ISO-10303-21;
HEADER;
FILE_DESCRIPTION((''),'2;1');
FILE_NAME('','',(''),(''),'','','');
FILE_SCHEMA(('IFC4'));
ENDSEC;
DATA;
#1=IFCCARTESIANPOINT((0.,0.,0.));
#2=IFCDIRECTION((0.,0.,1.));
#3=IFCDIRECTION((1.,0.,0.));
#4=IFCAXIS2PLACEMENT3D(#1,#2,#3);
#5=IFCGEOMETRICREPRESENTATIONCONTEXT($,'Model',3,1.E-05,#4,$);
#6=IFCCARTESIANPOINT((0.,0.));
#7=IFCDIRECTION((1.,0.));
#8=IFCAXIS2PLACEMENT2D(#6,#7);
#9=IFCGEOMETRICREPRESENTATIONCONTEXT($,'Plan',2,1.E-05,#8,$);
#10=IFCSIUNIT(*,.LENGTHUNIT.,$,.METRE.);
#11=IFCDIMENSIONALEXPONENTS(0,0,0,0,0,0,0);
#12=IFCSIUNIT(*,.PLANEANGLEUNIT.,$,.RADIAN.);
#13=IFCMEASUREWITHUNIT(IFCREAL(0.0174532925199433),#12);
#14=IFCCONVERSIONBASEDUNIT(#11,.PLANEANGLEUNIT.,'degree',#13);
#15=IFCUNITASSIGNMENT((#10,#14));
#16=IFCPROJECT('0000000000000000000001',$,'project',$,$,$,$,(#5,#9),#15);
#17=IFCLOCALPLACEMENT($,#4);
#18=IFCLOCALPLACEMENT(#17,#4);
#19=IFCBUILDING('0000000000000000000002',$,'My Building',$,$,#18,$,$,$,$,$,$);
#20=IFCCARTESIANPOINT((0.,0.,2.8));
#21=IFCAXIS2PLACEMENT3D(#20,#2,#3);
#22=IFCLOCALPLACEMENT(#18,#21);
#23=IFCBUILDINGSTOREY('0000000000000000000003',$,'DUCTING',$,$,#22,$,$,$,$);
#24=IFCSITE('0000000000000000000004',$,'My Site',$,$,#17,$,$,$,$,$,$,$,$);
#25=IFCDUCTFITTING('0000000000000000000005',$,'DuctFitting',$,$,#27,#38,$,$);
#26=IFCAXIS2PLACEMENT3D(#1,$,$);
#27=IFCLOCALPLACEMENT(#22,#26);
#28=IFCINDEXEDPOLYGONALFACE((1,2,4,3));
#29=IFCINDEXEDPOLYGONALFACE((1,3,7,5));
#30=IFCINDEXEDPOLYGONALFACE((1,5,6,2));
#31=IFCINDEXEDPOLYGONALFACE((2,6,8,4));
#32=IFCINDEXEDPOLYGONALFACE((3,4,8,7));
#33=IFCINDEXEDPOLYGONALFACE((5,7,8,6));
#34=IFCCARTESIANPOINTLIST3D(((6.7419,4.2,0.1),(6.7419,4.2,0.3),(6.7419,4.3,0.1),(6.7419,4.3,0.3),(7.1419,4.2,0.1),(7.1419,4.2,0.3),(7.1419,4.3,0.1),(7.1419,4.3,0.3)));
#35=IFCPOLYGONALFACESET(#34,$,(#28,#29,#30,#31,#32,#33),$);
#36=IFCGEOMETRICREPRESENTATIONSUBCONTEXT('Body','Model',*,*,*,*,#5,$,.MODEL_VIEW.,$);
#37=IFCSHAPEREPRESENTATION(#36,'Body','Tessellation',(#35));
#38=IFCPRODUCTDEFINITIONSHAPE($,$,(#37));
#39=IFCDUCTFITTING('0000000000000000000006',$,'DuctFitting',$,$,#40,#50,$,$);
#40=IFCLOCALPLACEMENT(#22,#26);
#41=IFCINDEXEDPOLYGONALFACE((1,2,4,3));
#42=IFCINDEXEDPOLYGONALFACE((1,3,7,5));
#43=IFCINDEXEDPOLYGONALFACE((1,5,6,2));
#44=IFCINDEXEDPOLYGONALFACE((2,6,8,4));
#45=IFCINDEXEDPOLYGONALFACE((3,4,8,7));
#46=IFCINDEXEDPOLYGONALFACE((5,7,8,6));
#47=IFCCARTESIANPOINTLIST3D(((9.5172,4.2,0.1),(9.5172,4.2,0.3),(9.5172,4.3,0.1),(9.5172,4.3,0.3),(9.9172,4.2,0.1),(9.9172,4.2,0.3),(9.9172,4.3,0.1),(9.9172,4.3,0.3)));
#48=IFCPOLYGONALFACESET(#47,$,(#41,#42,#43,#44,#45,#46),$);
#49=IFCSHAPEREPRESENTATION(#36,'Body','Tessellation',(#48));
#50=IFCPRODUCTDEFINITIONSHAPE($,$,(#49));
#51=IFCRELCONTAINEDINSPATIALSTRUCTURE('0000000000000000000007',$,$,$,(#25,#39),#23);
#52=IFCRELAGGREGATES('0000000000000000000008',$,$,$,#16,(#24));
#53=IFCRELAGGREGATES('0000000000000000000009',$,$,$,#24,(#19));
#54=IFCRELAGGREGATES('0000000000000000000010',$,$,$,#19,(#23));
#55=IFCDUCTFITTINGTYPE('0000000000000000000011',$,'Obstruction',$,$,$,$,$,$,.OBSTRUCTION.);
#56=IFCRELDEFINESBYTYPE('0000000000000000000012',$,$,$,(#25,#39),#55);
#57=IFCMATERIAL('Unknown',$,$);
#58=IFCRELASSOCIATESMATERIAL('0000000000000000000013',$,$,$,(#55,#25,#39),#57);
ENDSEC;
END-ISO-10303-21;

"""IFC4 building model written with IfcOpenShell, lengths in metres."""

from ifc_helpers import new_model, entity, si_unit, converted_unit, frame, origin_with_axes, origin_2d_with_axis, place, context, subcontext, project, spatial, rectangle, extrude, material, material_profile, profile_set, profile_usage, type_object, element, save


model = new_model("IFC4")

# Units and contexts
model_context = context("Model", 3, precision=1e-05, world=origin_with_axes())
plan_context = context("Plan", 2, precision=1e-05, world=origin_2d_with_axis())
body_context = subcontext(model_context, "Body", "Model", "MODEL_VIEW")
ifc_project = project(units=[si_unit("LENGTHUNIT", "METRE"), converted_unit("PLANEANGLEUNIT", "degree", entity("IfcReal", 0.0174532925199433), si_unit("PLANEANGLEUNIT", "RADIAN"), dimensions=[0, 0, 0, 0, 0, 0, 0])], contexts=[model_context, plan_context])

# Site, building, storey
site_placement = place(None, origin_with_axes())
site = spatial("IfcSite", under=ifc_project, at=site_placement, Name="My Site")
building_placement = place(site_placement, origin_with_axes())
building = spatial("IfcBuilding", under=site, at=building_placement, Name="My Building")
storey_placement = place(building_placement, frame((0.0, 0.0, 2.8), z_axis=(0.0, 0.0, 1.0), x_axis=(1.0, 0.0, 0.0)))
storey = spatial("IfcBuildingStorey", under=building, at=storey_placement, Name="DUCTING")

# Shared definitions
ifc_material = material(Name="Unknown")

# Duct fittings
ifc_material_profile_1 = material_profile(ifc_material, rectangle(XDim=0.4, YDim=0.2))
ifc_profile_set_1 = profile_set([ifc_material_profile_1])
duct_fitting_type_1 = type_object("IfcDuctFittingType", Name="Obstruction", PredefinedType="OBSTRUCTION", material=ifc_profile_set_1)
ifc_profile_usage_1 = profile_usage(ifc_profile_set_1, cardinal=5)
duct_fitting_1_placement = place(storey_placement, frame((6.9419, 4.3, 0.2), z_axis=(0.0, -1.0, 0.0), x_axis=(1.0, 0.0, 0.0)))
element("IfcDuctFitting", 1, at=duct_fitting_1_placement, inside=storey, type_object=duct_fitting_type_1, material=ifc_profile_usage_1, Name="DuctFitting", context=body_context, shape_type="SweptSolid", body=[
    extrude(rectangle(XDim=0.4, YDim=0.2), origin_with_axes(), (0.0, 0.0, 1.0), 0.1),
])
ifc_profile_usage_2 = profile_usage(ifc_profile_set_1, cardinal=5)
duct_fitting_2_placement = place(storey_placement, frame((9.7172, 4.3, 0.2), z_axis=(0.0, -1.0, 0.0), x_axis=(1.0, 0.0, 0.0)))
element("IfcDuctFitting", 2, at=duct_fitting_2_placement, inside=storey, type_object=duct_fitting_type_1, material=ifc_profile_usage_2, Name="DuctFitting", context=body_context, shape_type="SweptSolid", body=[
    extrude(rectangle(XDim=0.4, YDim=0.2), origin_with_axes(), (0.0, 0.0, 1.0), 0.1),
])

save(model, "model.ifc")
